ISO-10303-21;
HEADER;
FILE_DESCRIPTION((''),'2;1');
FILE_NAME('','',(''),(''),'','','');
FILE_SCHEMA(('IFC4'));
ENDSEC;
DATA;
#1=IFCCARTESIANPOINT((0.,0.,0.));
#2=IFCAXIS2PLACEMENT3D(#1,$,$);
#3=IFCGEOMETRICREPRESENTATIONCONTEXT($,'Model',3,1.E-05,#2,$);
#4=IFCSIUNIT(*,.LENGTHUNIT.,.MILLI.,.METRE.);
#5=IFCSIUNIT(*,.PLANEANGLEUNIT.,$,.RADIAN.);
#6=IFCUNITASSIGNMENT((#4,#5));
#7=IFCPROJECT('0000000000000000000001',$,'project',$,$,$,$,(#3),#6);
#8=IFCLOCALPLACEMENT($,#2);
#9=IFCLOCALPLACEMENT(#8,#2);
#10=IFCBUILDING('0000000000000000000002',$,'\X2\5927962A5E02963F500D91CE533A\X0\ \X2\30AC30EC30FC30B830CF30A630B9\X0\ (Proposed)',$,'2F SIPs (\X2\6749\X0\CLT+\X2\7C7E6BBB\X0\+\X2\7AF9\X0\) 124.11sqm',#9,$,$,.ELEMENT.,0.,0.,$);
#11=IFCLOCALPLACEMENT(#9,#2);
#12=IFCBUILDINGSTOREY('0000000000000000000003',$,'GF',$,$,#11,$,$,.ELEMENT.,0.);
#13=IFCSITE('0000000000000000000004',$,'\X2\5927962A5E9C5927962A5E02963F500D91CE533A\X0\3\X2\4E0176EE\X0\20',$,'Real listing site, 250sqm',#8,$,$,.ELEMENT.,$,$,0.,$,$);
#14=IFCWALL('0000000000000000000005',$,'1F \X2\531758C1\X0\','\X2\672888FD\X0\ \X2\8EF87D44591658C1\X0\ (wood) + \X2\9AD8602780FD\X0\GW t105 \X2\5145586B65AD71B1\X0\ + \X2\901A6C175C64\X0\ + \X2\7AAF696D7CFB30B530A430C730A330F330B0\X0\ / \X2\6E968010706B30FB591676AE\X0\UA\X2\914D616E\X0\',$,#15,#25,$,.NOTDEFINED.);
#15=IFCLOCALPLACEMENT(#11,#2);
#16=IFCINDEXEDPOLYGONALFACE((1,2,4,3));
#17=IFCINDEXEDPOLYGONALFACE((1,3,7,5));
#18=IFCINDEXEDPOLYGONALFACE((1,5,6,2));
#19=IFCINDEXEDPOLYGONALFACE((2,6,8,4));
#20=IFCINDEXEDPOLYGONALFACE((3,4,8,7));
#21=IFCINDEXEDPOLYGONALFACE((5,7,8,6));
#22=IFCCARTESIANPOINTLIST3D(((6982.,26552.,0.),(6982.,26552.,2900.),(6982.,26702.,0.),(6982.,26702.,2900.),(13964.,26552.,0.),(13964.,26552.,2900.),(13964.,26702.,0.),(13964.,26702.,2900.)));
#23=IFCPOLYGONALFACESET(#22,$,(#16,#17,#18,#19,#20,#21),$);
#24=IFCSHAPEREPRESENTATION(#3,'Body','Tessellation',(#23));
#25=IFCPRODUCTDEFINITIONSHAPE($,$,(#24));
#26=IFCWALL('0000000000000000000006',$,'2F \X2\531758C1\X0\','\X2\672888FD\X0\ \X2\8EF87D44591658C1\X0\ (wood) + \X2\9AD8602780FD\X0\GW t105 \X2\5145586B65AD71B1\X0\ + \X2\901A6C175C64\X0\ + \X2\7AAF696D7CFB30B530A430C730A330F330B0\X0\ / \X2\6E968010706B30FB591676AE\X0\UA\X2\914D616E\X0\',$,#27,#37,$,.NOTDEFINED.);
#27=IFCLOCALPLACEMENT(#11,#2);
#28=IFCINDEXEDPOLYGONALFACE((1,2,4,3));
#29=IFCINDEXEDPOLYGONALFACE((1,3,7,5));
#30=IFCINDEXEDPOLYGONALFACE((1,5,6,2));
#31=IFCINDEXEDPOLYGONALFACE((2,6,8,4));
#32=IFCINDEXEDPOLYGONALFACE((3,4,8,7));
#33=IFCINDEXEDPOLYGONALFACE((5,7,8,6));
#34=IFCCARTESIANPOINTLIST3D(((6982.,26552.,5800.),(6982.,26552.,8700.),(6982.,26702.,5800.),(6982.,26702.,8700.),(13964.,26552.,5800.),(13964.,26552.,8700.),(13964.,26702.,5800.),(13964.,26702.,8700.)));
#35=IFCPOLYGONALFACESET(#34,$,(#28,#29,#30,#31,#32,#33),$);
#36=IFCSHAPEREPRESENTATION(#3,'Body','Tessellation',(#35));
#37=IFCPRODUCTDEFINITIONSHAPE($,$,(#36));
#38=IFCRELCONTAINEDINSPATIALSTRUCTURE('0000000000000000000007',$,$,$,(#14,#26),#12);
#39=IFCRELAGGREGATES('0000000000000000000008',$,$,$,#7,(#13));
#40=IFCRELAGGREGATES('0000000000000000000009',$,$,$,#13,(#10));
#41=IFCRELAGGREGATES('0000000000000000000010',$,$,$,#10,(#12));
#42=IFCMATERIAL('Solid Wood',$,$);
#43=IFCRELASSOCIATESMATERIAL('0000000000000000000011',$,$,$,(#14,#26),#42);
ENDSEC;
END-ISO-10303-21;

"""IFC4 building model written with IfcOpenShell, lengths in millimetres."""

from ifc_helpers import new_model, si_unit, frame, frame_2d, origin, place, context, project, spatial, rectangle, extrude, material, element, save


model = new_model("IFC4")

# Units and contexts
model_context = context("Model", 3, precision=1e-05, world=origin())
ifc_project = project(units=[si_unit("LENGTHUNIT", "METRE", prefix="MILLI"), si_unit("PLANEANGLEUNIT", "RADIAN")], contexts=[model_context])

# Site, building, storey
site_placement = place(None, origin())
site = spatial("IfcSite", under=ifc_project, at=site_placement, Name="大阪府大阪市阿倍野区3丁目20", ObjectType="Real listing site, 250sqm", CompositionType="ELEMENT", RefElevation=0.0)
building_placement = place(site_placement, origin())
building = spatial("IfcBuilding", under=site, at=building_placement, Name="大阪市阿倍野区 ガレージハウス (Proposed)", ObjectType="2F SIPs (杉CLT+籾殻+竹) 124.11sqm", CompositionType="ELEMENT", ElevationOfRefHeight=0.0, ElevationOfTerrain=0.0)
storey_placement = place(building_placement, origin())
storey = spatial("IfcBuildingStorey", under=building, at=storey_placement, Name="GF", CompositionType="ELEMENT", Elevation=0.0)

# Shared definitions
ifc_material_1 = material(Name="Solid Wood")

# Wall
wall_1_placement = place(storey_placement, frame((3491.0, 13276.0, 0.0)))
element("IfcWall", 1, at=wall_1_placement, inside=storey, material=ifc_material_1, Name="1F 北壁", Description="木製 軸組外壁 (wood) + 高性能GW t105 充填断熱 + 通気層 + 窯業系サイディング / 準耐火・外皮UA配慮", PredefinedType="NOTDEFINED", context=model_context, shape_type="SweptSolid", body=[
    extrude(rectangle(XDim=6982.0, YDim=150.0, at=frame_2d((3491.0, 75.0))), frame((3491.0, 13276.0, 0.0)), (0.0, 0.0, 1.0), 2900.0),
])

# Wall
wall_2_placement = place(storey_placement, frame((3491.0, 13276.0, 2900.0)))
element("IfcWall", 2, at=wall_2_placement, inside=storey, material=ifc_material_1, Name="2F 北壁", Description="木製 軸組外壁 (wood) + 高性能GW t105 充填断熱 + 通気層 + 窯業系サイディング / 準耐火・外皮UA配慮", PredefinedType="NOTDEFINED", context=model_context, shape_type="SweptSolid", body=[
    extrude(rectangle(XDim=6982.0, YDim=150.0, at=frame_2d((3491.0, 75.0))), frame((3491.0, 13276.0, 2900.0)), (0.0, 0.0, 1.0), 2900.0),
])

save(model, "model.ifc")
